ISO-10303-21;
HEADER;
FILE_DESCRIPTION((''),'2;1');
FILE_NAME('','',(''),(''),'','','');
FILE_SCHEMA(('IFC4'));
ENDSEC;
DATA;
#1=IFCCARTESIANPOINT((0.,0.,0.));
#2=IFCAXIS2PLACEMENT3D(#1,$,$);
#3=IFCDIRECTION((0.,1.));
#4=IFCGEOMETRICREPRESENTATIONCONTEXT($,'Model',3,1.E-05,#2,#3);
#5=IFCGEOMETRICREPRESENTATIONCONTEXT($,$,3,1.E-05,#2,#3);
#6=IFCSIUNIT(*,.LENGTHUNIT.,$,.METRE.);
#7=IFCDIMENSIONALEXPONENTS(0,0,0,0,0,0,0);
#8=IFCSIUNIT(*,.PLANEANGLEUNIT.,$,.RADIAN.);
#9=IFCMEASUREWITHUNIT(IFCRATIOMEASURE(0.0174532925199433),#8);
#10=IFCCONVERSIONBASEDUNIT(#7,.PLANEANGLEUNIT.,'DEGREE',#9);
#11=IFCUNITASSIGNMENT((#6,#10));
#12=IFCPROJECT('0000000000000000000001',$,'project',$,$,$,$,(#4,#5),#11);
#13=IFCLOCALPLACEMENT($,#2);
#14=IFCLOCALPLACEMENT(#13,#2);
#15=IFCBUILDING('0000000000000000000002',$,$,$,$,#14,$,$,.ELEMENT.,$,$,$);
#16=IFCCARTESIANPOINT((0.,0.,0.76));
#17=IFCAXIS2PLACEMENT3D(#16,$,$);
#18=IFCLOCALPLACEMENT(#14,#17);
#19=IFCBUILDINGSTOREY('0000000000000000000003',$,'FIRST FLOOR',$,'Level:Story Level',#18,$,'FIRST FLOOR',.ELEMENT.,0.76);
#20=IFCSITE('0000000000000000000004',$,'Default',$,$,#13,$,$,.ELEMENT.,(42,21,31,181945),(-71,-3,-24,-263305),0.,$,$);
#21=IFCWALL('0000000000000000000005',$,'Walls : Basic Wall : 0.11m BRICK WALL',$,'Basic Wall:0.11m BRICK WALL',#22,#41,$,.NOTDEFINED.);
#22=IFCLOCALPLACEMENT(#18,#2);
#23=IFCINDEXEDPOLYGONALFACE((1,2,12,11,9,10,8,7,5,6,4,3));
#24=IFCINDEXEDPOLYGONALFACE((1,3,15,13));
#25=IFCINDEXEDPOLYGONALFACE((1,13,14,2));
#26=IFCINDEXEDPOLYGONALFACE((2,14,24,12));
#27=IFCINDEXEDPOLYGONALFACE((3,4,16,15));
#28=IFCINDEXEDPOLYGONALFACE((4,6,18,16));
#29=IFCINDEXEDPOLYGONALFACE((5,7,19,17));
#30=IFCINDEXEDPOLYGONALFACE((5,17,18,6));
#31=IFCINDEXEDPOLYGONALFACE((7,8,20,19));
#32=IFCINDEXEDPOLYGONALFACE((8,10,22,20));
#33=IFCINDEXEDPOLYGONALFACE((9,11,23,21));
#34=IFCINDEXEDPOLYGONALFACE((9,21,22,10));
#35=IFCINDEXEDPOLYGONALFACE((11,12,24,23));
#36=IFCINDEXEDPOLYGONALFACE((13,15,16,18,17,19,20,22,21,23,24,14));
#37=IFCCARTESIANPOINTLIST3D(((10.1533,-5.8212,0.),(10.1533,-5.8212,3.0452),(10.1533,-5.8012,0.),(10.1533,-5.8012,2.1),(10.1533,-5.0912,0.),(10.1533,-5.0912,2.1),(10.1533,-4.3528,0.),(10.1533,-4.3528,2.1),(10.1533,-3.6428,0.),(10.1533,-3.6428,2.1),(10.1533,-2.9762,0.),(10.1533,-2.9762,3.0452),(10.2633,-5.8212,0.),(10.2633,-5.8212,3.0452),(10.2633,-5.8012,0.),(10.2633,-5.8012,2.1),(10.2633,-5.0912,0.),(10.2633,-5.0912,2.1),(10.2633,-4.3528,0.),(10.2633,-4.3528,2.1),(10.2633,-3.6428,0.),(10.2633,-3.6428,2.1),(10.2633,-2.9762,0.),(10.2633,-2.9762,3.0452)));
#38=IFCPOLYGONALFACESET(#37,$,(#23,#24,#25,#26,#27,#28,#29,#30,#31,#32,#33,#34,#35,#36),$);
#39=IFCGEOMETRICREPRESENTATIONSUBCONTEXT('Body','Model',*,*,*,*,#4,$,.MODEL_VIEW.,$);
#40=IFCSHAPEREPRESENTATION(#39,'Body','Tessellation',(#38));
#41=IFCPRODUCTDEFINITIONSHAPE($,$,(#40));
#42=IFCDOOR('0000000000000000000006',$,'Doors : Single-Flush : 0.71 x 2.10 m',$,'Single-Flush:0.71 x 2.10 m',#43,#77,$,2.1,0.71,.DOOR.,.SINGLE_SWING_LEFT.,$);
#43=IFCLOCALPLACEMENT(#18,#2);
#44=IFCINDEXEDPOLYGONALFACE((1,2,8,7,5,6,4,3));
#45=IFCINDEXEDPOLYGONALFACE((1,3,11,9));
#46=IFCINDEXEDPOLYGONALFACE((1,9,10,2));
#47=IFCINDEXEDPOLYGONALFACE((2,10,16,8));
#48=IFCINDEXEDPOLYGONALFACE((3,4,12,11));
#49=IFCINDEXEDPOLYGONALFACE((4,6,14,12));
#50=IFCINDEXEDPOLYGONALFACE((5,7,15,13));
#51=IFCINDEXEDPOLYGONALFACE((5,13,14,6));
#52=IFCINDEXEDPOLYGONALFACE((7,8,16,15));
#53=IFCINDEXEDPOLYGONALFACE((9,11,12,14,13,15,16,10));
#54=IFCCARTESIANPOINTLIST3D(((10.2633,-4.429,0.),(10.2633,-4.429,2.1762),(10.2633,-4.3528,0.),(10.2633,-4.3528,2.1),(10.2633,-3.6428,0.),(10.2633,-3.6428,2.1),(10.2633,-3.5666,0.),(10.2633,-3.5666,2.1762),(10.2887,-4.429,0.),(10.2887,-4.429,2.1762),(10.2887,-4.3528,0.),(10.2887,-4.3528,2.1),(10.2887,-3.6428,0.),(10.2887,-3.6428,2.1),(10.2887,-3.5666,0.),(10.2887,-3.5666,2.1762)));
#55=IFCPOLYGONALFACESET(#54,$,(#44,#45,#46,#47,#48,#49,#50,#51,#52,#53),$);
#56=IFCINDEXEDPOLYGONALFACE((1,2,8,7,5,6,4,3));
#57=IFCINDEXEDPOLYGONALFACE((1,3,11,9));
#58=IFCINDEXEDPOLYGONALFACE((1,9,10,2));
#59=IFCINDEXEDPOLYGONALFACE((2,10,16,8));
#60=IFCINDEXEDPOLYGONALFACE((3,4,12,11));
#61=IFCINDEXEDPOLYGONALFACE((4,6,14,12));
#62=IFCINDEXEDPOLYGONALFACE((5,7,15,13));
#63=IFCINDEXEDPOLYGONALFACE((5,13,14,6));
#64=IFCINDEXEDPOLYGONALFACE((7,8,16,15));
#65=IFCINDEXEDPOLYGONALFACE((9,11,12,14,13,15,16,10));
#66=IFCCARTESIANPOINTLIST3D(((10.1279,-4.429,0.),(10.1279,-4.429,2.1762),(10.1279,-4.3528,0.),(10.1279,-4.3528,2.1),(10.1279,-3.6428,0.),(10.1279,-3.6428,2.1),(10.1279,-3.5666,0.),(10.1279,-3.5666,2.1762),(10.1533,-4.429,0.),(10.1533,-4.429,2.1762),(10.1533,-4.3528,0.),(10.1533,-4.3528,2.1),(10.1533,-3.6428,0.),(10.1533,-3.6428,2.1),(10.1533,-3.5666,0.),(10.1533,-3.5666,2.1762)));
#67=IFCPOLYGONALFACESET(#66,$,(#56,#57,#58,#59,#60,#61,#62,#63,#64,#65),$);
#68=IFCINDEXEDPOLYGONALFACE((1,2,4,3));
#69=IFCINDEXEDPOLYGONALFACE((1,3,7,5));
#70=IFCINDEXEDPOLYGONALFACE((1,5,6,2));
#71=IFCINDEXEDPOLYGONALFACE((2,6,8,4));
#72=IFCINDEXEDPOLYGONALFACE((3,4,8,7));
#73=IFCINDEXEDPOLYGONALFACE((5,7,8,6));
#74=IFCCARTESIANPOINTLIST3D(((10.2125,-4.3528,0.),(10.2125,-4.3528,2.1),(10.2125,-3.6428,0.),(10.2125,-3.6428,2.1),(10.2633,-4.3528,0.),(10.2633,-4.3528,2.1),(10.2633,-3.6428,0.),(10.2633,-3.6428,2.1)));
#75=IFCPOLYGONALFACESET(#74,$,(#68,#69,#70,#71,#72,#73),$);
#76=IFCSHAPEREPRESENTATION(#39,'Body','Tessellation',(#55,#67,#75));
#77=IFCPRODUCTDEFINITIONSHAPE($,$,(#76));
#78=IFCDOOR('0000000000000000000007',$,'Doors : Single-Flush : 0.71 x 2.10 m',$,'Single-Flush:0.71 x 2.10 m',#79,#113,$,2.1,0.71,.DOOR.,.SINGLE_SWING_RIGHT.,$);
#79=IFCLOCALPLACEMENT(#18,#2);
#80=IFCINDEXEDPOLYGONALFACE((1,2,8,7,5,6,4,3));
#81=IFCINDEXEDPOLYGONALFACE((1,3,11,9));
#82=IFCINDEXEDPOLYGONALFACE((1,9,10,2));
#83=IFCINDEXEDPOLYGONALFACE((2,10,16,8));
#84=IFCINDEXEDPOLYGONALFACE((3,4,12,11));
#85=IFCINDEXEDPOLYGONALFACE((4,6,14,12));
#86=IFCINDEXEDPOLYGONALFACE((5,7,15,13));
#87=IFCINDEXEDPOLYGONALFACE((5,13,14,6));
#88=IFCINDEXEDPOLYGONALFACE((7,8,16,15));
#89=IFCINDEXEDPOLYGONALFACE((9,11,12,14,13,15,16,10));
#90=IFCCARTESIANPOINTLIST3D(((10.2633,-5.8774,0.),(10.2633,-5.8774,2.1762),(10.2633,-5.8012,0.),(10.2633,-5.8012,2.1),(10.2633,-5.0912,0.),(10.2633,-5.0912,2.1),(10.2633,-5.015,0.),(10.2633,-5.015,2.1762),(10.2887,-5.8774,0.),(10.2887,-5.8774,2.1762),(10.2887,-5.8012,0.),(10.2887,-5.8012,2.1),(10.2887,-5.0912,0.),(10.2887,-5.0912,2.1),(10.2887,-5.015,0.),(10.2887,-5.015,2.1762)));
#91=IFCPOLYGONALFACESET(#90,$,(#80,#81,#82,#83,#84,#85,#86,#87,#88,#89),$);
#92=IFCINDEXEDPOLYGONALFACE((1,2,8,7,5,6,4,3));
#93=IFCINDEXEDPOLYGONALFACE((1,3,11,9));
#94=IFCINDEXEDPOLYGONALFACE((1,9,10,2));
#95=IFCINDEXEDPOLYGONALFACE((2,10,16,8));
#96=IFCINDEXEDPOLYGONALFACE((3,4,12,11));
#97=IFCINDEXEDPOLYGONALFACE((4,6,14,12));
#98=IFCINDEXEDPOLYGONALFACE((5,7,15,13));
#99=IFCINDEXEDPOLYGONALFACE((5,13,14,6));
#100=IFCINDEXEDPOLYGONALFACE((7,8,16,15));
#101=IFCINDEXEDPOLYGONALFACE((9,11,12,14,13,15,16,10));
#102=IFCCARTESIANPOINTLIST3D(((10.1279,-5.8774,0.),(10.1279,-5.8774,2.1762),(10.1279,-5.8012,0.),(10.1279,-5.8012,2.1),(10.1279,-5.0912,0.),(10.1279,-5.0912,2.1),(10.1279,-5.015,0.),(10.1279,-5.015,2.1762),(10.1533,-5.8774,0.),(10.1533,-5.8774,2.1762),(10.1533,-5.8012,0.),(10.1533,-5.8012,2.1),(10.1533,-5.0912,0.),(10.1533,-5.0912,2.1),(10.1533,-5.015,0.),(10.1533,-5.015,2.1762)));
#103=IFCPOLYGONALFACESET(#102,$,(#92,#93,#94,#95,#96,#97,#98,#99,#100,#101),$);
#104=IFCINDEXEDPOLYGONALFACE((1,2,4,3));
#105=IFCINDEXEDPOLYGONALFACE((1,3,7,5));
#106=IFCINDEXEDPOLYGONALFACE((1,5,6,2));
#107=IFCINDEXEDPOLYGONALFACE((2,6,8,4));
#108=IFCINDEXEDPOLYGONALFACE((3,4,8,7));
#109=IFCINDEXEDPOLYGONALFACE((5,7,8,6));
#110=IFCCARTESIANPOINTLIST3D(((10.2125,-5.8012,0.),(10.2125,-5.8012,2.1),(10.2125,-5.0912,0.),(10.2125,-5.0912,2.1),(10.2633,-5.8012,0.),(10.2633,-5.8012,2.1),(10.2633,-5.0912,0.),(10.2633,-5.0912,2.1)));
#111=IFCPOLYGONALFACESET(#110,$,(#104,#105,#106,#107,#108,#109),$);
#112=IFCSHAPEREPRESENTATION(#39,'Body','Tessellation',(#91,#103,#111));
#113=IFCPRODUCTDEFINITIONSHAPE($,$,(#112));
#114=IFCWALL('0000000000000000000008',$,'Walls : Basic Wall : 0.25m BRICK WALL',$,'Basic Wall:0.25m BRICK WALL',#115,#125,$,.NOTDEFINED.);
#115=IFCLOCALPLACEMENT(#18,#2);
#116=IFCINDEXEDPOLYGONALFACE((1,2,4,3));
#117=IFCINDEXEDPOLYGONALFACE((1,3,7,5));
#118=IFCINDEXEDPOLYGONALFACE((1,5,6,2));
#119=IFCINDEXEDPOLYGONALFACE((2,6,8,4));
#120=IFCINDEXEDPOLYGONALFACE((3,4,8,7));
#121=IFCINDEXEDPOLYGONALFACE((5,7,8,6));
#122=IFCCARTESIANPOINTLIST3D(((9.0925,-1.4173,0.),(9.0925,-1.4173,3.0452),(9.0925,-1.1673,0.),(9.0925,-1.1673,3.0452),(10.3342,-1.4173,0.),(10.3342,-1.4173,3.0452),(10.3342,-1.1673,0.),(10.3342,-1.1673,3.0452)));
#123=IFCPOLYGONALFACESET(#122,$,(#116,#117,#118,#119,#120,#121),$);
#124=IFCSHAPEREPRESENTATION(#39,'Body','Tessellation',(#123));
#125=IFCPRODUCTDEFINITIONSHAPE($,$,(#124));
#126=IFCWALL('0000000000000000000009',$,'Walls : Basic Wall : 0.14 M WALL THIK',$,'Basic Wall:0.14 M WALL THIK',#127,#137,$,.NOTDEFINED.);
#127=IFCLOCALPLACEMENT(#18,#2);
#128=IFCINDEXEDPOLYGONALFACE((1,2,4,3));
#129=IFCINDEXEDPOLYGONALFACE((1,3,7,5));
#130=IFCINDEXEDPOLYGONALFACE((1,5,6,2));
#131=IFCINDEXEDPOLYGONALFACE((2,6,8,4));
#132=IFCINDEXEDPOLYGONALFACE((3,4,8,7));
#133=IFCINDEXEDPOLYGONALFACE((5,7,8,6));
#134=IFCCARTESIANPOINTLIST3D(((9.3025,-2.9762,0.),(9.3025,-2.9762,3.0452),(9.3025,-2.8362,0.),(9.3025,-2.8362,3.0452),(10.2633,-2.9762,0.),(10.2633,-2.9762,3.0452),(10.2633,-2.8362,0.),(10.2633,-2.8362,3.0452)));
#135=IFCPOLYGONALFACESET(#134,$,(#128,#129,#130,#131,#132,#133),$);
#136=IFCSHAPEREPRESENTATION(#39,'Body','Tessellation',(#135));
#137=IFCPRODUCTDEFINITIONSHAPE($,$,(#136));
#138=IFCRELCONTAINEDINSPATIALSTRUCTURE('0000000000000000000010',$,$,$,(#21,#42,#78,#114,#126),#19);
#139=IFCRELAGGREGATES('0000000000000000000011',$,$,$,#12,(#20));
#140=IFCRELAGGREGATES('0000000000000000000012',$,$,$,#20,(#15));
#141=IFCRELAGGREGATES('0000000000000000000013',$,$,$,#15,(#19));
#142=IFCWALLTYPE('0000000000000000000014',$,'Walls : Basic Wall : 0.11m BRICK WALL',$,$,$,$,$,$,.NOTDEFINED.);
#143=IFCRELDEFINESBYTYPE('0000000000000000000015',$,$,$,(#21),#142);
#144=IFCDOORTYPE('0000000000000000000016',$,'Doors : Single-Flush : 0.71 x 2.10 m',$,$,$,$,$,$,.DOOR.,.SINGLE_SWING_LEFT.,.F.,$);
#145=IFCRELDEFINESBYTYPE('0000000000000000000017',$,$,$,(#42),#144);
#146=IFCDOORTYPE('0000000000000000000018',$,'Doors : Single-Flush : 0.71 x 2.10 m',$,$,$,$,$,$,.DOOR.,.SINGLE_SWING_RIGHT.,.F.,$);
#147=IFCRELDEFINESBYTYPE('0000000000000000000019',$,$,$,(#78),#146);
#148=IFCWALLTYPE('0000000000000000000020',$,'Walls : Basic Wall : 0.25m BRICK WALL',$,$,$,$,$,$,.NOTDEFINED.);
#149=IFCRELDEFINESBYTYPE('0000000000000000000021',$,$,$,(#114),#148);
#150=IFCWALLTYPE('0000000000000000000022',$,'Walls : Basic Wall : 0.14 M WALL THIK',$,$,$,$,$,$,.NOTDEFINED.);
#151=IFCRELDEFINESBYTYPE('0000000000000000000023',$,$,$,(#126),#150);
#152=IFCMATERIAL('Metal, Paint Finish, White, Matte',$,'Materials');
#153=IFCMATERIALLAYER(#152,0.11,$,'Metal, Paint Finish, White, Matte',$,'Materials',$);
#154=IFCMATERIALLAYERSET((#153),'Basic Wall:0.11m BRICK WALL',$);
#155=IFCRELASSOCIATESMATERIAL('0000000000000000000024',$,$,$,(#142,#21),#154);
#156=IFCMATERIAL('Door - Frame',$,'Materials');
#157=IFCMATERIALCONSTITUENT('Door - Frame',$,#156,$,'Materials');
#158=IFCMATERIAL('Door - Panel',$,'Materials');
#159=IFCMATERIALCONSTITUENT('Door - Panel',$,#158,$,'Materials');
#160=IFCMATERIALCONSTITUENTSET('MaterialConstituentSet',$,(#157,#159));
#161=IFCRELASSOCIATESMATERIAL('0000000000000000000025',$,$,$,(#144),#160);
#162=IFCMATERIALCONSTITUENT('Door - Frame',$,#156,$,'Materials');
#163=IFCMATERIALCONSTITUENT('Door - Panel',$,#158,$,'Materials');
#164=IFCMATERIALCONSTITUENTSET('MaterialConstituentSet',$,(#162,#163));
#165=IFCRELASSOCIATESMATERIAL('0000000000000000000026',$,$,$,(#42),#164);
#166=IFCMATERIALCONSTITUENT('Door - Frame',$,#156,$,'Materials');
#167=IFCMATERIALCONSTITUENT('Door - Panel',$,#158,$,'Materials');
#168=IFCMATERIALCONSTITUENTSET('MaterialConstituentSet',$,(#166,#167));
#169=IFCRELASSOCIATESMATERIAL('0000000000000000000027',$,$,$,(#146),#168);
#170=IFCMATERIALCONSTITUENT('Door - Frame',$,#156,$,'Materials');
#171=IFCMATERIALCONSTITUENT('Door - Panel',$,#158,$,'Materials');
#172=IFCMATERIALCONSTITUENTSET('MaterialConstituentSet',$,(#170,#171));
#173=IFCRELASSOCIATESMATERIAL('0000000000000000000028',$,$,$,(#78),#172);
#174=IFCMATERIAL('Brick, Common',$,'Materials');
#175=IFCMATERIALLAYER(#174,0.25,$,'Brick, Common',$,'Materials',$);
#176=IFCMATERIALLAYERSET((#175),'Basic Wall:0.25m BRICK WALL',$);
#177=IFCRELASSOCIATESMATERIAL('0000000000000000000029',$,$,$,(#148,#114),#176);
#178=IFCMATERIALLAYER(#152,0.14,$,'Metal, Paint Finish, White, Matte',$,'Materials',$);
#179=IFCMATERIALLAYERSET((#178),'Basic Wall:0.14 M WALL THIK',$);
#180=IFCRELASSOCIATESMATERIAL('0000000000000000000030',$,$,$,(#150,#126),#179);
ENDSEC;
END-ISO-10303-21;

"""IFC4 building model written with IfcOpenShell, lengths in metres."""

from ifc_helpers import new_model, entity, si_unit, converted_unit, direction, frame, frame_2d, origin, origin_2d_with_axis, place, context, subcontext, project, spatial, polyline, rectangle, outline, extrude, source, transform, mapped, material, layer, layer_set, layer_usage, constituent, constituent_set, type_object, type_shapes, element, fill, save


model = new_model("IFC4")

# Units and contexts
model_context = context("Model", 3, precision=1e-05, world=origin(), true_north=direction((0.0, 1.0)))
context_of_model = context(None, 3, precision=1e-05, world=origin(), true_north=direction((0.0, 1.0)))
body_context = subcontext(model_context, "Body", "Model", "MODEL_VIEW")
ifc_project = project(units=[si_unit("LENGTHUNIT", "METRE"), converted_unit("PLANEANGLEUNIT", "DEGREE", entity("IfcRatioMeasure", 0.0174532925199433), si_unit("PLANEANGLEUNIT", "RADIAN"), dimensions=[0, 0, 0, 0, 0, 0, 0])], contexts=[model_context, context_of_model])

# Site, building, storey
site_placement = place(None, origin())
site = spatial("IfcSite", under=ifc_project, at=site_placement, Name="Default", CompositionType="ELEMENT", RefLatitude=(42, 21, 31, 181945), RefLongitude=(-71, -3, -24, -263305), RefElevation=0.0)
building_placement = place(site_placement, origin())
building = spatial("IfcBuilding", under=site, at=building_placement, CompositionType="ELEMENT")
storey_placement = place(building_placement, frame((0.0, 0.0, 0.76)))
storey = spatial("IfcBuildingStorey", under=building, at=storey_placement, Name="FIRST FLOOR", ObjectType="Level:Story Level", LongName="FIRST FLOOR", CompositionType="ELEMENT", Elevation=0.76)

# Shared definitions
ifc_material_1 = material(Name="Brick, Common", Category="Materials")
ifc_material_2 = material(Name="Metal, Paint Finish, White, Matte", Category="Materials")

# Shared definitions
ifc_material_3 = material(Name="Door - Frame", Category="Materials")
ifc_material_4 = material(Name="Door - Panel", Category="Materials")

# Wall, openings, doors
ifc_layer_1 = layer(ifc_material_2, 0.11, Name="Metal, Paint Finish, White, Matte", Category="Materials")
ifc_layer_set_1 = layer_set([ifc_layer_1], Name="Basic Wall:0.11m BRICK WALL")
ifc_layer_usage_1 = layer_usage(ifc_layer_set_1, "AXIS2", "NEGATIVE", 0.055)
wall_type_1 = type_object("IfcWallType", Name="Walls : Basic Wall : 0.11m BRICK WALL", PredefinedType="NOTDEFINED", material=ifc_layer_set_1)
wall_1_placement = place(storey_placement, frame((10.2083, -2.9762, 0.0), z_axis=(0.0, 0.0, 1.0), x_axis=(0.0, -1.0, 0.0)))
wall_1 = element("IfcWall", 1, at=wall_1_placement, inside=storey, type_object=wall_type_1, material=ifc_layer_usage_1, Name="Walls : Basic Wall : 0.11m BRICK WALL", ObjectType="Basic Wall:0.11m BRICK WALL", PredefinedType="NOTDEFINED", context=body_context, shape_type="SweptSolid", body=[
    extrude(rectangle(XDim=2.8451, YDim=0.11, at=frame_2d((1.4225, 0.0), x_axis=(-1.0, 0.0))), origin(), (0.0, 0.0, 1.0), 3.0452),
])
opening_1_placement = place(wall_1_placement, frame((0.6666, -0.055, 0.0)))
opening_1 = element("IfcOpeningElement", 2, at=opening_1_placement, cuts=wall_1, ObjectType="Opening", PredefinedType="OPENING", context=body_context, shape_type="SweptSolid", body=[
    extrude(rectangle(XDim=0.71, YDim=2.1, at=frame_2d((1.05, 0.355), x_axis=(0.0, -1.0))), frame((0.0, 0.0, 0.0), z_axis=(0.0, 1.0, 0.0), x_axis=(0.0, 0.0, 1.0)), (0.0, 0.0, 1.0), 0.11),
])
opening_2_placement = place(wall_1_placement, frame((2.1151, -0.055, 0.0)))
opening_2 = element("IfcOpeningElement", 3, at=opening_2_placement, cuts=wall_1, ObjectType="Opening", PredefinedType="OPENING", context=body_context, shape_type="SweptSolid", body=[
    extrude(rectangle(XDim=0.71, YDim=2.1, at=frame_2d((1.05, 0.355), x_axis=(0.0, 1.0))), frame((0.0, 0.0, 0.0), z_axis=(0.0, 1.0, 0.0), x_axis=(0.0, 0.0, 1.0)), (0.0, 0.0, 1.0), 0.11),
])
ifc_constituent_1 = constituent(ifc_material_3, Name="Door - Frame", Category="Materials")
ifc_constituent_2 = constituent(ifc_material_4, Name="Door - Panel", Category="Materials")
ifc_constituent_set_1 = constituent_set(constituents=[ifc_constituent_1, ifc_constituent_2], Name="MaterialConstituentSet")
ifc_constituent_3 = constituent(ifc_material_3, Name="Door - Frame", Category="Materials")
ifc_constituent_4 = constituent(ifc_material_4, Name="Door - Panel", Category="Materials")
ifc_constituent_set_2 = constituent_set(constituents=[ifc_constituent_3, ifc_constituent_4], Name="MaterialConstituentSet")
door_type_1 = type_object("IfcDoorType", Name="Doors : Single-Flush : 0.71 x 2.10 m", OperationType="SINGLE_SWING_LEFT", ParameterTakesPrecedence=False, PredefinedType="DOOR", material=ifc_constituent_set_2)
shared_shape_1 = source(origin(), body_context, "Body", "SweptSolid", [
    extrude(outline(polyline([(-0.4312, -1.1072), (0.4312, -1.1072), (0.4312, 1.0691), (0.355, 1.0691), (0.355, -1.031), (-0.355, -1.031), (-0.355, 1.0691), (-0.4312, 1.0691), (-0.4312, -1.1072)])), frame((0.355, 0.1354, 1.0691), z_axis=(0.0, -1.0, 0.0), x_axis=(-1.0, 0.0, 0.0)), (0.0, 0.0, 1.0), 0.0254),
    extrude(outline(polyline([(-1.1072, -0.4312), (1.0691, -0.4312), (1.0691, -0.355), (-1.031, -0.355), (-1.031, 0.355), (1.0691, 0.355), (1.0691, 0.4312), (-1.1072, 0.4312), (-1.1072, -0.4312)])), frame((0.355, 0.0, 1.0691), z_axis=(0.0, -1.0, 0.0), x_axis=(0.0, 0.0, -1.0)), (0.0, 0.0, 1.0), 0.0254),
    extrude(rectangle(XDim=0.71, YDim=0.0508, at=origin_2d_with_axis()), frame((0.355, 0.0846, 0.0)), (0.0, 0.0, 1.0), 2.1),
])
type_shapes(door_type_1, [shared_shape_1])
door_1_placement = place(opening_1_placement, origin())
door_1 = element("IfcDoor", 4, at=door_1_placement, inside=storey, type_object=door_type_1, material=ifc_constituent_set_1, Name="Doors : Single-Flush : 0.71 x 2.10 m", ObjectType="Single-Flush:0.71 x 2.10 m", OperationType="SINGLE_SWING_LEFT", OverallHeight=2.1, OverallWidth=0.71, PredefinedType="DOOR", context=body_context, shape_type="MappedRepresentation", body=[
    mapped(shared_shape_1, transform((0.0, 0.0, 0.0), scale=1.0)),
])
fill(opening_1, door_1)
ifc_constituent_5 = constituent(ifc_material_3, Name="Door - Frame", Category="Materials")
ifc_constituent_6 = constituent(ifc_material_4, Name="Door - Panel", Category="Materials")
ifc_constituent_set_3 = constituent_set(constituents=[ifc_constituent_5, ifc_constituent_6], Name="MaterialConstituentSet")
ifc_constituent_7 = constituent(ifc_material_3, Name="Door - Frame", Category="Materials")
ifc_constituent_8 = constituent(ifc_material_4, Name="Door - Panel", Category="Materials")
ifc_constituent_set_4 = constituent_set(constituents=[ifc_constituent_7, ifc_constituent_8], Name="MaterialConstituentSet")
door_type_2 = type_object("IfcDoorType", Name="Doors : Single-Flush : 0.71 x 2.10 m", OperationType="SINGLE_SWING_RIGHT", ParameterTakesPrecedence=False, PredefinedType="DOOR", material=ifc_constituent_set_4)
shared_shape_2 = source(origin(), body_context, "Body", "SweptSolid", [
    extrude(outline(polyline([(-0.4312, -1.1072), (0.4312, -1.1072), (0.4312, 1.0691), (0.355, 1.0691), (0.355, -1.031), (-0.355, -1.031), (-0.355, 1.0691), (-0.4312, 1.0691), (-0.4312, -1.1072)])), frame((0.355, 0.11, 1.0691), z_axis=(0.0, 1.0, 0.0), x_axis=(1.0, 0.0, 0.0)), (0.0, 0.0, 1.0), 0.0254),
    extrude(outline(polyline([(-1.1072, -0.4312), (1.0691, -0.4312), (1.0691, -0.355), (-1.031, -0.355), (-1.031, 0.355), (1.0691, 0.355), (1.0691, 0.4312), (-1.1072, 0.4312), (-1.1072, -0.4312)])), frame((0.355, -0.0254, 1.0691), z_axis=(0.0, 1.0, 0.0), x_axis=(0.0, 0.0, -1.0)), (0.0, 0.0, 1.0), 0.0254),
    extrude(rectangle(XDim=0.0508, YDim=0.71, at=origin_2d_with_axis()), frame((0.355, 0.0846, 0.0), z_axis=(0.0, 0.0, 1.0), x_axis=(0.0, 1.0, 0.0)), (0.0, 0.0, 1.0), 2.1),
])
type_shapes(door_type_2, [shared_shape_2])
door_2_placement = place(opening_2_placement, origin())
door_2 = element("IfcDoor", 5, at=door_2_placement, inside=storey, type_object=door_type_2, material=ifc_constituent_set_3, Name="Doors : Single-Flush : 0.71 x 2.10 m", ObjectType="Single-Flush:0.71 x 2.10 m", OperationType="SINGLE_SWING_RIGHT", OverallHeight=2.1, OverallWidth=0.71, PredefinedType="DOOR", context=body_context, shape_type="MappedRepresentation", body=[
    mapped(shared_shape_2, transform((0.0, 0.0, 0.0), scale=1.0)),
])
fill(opening_2, door_2)

# Walls
ifc_layer_2 = layer(ifc_material_1, 0.25, Name="Brick, Common", Category="Materials")
ifc_layer_set_2 = layer_set([ifc_layer_2], Name="Basic Wall:0.25m BRICK WALL")
ifc_layer_usage_2 = layer_usage(ifc_layer_set_2, "AXIS2", "NEGATIVE", 0.125)
wall_type_2 = type_object("IfcWallType", Name="Walls : Basic Wall : 0.25m BRICK WALL", PredefinedType="NOTDEFINED", material=ifc_layer_set_2)
wall_2_placement = place(storey_placement, frame((10.3342, -1.2923, 0.0), z_axis=(0.0, 0.0, 1.0), x_axis=(-1.0, 0.0, 0.0)))
element("IfcWall", 6, at=wall_2_placement, inside=storey, type_object=wall_type_2, material=ifc_layer_usage_2, Name="Walls : Basic Wall : 0.25m BRICK WALL", ObjectType="Basic Wall:0.25m BRICK WALL", PredefinedType="NOTDEFINED", context=body_context, shape_type="SweptSolid", body=[
    extrude(rectangle(XDim=1.2417, YDim=0.25, at=frame_2d((0.6208, 0.0), x_axis=(-1.0, 0.0))), origin(), (0.0, 0.0, 1.0), 3.0452),
])
ifc_layer_3 = layer(ifc_material_2, 0.14, Name="Metal, Paint Finish, White, Matte", Category="Materials")
ifc_layer_set_3 = layer_set([ifc_layer_3], Name="Basic Wall:0.14 M WALL THIK")
ifc_layer_usage_3 = layer_usage(ifc_layer_set_3, "AXIS2", "NEGATIVE", 0.07)
wall_type_3 = type_object("IfcWallType", Name="Walls : Basic Wall : 0.14 M WALL THIK", PredefinedType="NOTDEFINED", material=ifc_layer_set_3)
wall_3_placement = place(storey_placement, frame((10.2633, -2.9062, 0.0), z_axis=(0.0, 0.0, 1.0), x_axis=(-1.0, 0.0, 0.0)))
element("IfcWall", 7, at=wall_3_placement, inside=storey, type_object=wall_type_3, material=ifc_layer_usage_3, Name="Walls : Basic Wall : 0.14 M WALL THIK", ObjectType="Basic Wall:0.14 M WALL THIK", PredefinedType="NOTDEFINED", context=body_context, shape_type="SweptSolid", body=[
    extrude(rectangle(XDim=0.9607, YDim=0.14, at=frame_2d((0.4804, 0.0), x_axis=(-1.0, 0.0))), origin(), (0.0, 0.0, 1.0), 3.0452),
])

save(model, "model.ifc")
